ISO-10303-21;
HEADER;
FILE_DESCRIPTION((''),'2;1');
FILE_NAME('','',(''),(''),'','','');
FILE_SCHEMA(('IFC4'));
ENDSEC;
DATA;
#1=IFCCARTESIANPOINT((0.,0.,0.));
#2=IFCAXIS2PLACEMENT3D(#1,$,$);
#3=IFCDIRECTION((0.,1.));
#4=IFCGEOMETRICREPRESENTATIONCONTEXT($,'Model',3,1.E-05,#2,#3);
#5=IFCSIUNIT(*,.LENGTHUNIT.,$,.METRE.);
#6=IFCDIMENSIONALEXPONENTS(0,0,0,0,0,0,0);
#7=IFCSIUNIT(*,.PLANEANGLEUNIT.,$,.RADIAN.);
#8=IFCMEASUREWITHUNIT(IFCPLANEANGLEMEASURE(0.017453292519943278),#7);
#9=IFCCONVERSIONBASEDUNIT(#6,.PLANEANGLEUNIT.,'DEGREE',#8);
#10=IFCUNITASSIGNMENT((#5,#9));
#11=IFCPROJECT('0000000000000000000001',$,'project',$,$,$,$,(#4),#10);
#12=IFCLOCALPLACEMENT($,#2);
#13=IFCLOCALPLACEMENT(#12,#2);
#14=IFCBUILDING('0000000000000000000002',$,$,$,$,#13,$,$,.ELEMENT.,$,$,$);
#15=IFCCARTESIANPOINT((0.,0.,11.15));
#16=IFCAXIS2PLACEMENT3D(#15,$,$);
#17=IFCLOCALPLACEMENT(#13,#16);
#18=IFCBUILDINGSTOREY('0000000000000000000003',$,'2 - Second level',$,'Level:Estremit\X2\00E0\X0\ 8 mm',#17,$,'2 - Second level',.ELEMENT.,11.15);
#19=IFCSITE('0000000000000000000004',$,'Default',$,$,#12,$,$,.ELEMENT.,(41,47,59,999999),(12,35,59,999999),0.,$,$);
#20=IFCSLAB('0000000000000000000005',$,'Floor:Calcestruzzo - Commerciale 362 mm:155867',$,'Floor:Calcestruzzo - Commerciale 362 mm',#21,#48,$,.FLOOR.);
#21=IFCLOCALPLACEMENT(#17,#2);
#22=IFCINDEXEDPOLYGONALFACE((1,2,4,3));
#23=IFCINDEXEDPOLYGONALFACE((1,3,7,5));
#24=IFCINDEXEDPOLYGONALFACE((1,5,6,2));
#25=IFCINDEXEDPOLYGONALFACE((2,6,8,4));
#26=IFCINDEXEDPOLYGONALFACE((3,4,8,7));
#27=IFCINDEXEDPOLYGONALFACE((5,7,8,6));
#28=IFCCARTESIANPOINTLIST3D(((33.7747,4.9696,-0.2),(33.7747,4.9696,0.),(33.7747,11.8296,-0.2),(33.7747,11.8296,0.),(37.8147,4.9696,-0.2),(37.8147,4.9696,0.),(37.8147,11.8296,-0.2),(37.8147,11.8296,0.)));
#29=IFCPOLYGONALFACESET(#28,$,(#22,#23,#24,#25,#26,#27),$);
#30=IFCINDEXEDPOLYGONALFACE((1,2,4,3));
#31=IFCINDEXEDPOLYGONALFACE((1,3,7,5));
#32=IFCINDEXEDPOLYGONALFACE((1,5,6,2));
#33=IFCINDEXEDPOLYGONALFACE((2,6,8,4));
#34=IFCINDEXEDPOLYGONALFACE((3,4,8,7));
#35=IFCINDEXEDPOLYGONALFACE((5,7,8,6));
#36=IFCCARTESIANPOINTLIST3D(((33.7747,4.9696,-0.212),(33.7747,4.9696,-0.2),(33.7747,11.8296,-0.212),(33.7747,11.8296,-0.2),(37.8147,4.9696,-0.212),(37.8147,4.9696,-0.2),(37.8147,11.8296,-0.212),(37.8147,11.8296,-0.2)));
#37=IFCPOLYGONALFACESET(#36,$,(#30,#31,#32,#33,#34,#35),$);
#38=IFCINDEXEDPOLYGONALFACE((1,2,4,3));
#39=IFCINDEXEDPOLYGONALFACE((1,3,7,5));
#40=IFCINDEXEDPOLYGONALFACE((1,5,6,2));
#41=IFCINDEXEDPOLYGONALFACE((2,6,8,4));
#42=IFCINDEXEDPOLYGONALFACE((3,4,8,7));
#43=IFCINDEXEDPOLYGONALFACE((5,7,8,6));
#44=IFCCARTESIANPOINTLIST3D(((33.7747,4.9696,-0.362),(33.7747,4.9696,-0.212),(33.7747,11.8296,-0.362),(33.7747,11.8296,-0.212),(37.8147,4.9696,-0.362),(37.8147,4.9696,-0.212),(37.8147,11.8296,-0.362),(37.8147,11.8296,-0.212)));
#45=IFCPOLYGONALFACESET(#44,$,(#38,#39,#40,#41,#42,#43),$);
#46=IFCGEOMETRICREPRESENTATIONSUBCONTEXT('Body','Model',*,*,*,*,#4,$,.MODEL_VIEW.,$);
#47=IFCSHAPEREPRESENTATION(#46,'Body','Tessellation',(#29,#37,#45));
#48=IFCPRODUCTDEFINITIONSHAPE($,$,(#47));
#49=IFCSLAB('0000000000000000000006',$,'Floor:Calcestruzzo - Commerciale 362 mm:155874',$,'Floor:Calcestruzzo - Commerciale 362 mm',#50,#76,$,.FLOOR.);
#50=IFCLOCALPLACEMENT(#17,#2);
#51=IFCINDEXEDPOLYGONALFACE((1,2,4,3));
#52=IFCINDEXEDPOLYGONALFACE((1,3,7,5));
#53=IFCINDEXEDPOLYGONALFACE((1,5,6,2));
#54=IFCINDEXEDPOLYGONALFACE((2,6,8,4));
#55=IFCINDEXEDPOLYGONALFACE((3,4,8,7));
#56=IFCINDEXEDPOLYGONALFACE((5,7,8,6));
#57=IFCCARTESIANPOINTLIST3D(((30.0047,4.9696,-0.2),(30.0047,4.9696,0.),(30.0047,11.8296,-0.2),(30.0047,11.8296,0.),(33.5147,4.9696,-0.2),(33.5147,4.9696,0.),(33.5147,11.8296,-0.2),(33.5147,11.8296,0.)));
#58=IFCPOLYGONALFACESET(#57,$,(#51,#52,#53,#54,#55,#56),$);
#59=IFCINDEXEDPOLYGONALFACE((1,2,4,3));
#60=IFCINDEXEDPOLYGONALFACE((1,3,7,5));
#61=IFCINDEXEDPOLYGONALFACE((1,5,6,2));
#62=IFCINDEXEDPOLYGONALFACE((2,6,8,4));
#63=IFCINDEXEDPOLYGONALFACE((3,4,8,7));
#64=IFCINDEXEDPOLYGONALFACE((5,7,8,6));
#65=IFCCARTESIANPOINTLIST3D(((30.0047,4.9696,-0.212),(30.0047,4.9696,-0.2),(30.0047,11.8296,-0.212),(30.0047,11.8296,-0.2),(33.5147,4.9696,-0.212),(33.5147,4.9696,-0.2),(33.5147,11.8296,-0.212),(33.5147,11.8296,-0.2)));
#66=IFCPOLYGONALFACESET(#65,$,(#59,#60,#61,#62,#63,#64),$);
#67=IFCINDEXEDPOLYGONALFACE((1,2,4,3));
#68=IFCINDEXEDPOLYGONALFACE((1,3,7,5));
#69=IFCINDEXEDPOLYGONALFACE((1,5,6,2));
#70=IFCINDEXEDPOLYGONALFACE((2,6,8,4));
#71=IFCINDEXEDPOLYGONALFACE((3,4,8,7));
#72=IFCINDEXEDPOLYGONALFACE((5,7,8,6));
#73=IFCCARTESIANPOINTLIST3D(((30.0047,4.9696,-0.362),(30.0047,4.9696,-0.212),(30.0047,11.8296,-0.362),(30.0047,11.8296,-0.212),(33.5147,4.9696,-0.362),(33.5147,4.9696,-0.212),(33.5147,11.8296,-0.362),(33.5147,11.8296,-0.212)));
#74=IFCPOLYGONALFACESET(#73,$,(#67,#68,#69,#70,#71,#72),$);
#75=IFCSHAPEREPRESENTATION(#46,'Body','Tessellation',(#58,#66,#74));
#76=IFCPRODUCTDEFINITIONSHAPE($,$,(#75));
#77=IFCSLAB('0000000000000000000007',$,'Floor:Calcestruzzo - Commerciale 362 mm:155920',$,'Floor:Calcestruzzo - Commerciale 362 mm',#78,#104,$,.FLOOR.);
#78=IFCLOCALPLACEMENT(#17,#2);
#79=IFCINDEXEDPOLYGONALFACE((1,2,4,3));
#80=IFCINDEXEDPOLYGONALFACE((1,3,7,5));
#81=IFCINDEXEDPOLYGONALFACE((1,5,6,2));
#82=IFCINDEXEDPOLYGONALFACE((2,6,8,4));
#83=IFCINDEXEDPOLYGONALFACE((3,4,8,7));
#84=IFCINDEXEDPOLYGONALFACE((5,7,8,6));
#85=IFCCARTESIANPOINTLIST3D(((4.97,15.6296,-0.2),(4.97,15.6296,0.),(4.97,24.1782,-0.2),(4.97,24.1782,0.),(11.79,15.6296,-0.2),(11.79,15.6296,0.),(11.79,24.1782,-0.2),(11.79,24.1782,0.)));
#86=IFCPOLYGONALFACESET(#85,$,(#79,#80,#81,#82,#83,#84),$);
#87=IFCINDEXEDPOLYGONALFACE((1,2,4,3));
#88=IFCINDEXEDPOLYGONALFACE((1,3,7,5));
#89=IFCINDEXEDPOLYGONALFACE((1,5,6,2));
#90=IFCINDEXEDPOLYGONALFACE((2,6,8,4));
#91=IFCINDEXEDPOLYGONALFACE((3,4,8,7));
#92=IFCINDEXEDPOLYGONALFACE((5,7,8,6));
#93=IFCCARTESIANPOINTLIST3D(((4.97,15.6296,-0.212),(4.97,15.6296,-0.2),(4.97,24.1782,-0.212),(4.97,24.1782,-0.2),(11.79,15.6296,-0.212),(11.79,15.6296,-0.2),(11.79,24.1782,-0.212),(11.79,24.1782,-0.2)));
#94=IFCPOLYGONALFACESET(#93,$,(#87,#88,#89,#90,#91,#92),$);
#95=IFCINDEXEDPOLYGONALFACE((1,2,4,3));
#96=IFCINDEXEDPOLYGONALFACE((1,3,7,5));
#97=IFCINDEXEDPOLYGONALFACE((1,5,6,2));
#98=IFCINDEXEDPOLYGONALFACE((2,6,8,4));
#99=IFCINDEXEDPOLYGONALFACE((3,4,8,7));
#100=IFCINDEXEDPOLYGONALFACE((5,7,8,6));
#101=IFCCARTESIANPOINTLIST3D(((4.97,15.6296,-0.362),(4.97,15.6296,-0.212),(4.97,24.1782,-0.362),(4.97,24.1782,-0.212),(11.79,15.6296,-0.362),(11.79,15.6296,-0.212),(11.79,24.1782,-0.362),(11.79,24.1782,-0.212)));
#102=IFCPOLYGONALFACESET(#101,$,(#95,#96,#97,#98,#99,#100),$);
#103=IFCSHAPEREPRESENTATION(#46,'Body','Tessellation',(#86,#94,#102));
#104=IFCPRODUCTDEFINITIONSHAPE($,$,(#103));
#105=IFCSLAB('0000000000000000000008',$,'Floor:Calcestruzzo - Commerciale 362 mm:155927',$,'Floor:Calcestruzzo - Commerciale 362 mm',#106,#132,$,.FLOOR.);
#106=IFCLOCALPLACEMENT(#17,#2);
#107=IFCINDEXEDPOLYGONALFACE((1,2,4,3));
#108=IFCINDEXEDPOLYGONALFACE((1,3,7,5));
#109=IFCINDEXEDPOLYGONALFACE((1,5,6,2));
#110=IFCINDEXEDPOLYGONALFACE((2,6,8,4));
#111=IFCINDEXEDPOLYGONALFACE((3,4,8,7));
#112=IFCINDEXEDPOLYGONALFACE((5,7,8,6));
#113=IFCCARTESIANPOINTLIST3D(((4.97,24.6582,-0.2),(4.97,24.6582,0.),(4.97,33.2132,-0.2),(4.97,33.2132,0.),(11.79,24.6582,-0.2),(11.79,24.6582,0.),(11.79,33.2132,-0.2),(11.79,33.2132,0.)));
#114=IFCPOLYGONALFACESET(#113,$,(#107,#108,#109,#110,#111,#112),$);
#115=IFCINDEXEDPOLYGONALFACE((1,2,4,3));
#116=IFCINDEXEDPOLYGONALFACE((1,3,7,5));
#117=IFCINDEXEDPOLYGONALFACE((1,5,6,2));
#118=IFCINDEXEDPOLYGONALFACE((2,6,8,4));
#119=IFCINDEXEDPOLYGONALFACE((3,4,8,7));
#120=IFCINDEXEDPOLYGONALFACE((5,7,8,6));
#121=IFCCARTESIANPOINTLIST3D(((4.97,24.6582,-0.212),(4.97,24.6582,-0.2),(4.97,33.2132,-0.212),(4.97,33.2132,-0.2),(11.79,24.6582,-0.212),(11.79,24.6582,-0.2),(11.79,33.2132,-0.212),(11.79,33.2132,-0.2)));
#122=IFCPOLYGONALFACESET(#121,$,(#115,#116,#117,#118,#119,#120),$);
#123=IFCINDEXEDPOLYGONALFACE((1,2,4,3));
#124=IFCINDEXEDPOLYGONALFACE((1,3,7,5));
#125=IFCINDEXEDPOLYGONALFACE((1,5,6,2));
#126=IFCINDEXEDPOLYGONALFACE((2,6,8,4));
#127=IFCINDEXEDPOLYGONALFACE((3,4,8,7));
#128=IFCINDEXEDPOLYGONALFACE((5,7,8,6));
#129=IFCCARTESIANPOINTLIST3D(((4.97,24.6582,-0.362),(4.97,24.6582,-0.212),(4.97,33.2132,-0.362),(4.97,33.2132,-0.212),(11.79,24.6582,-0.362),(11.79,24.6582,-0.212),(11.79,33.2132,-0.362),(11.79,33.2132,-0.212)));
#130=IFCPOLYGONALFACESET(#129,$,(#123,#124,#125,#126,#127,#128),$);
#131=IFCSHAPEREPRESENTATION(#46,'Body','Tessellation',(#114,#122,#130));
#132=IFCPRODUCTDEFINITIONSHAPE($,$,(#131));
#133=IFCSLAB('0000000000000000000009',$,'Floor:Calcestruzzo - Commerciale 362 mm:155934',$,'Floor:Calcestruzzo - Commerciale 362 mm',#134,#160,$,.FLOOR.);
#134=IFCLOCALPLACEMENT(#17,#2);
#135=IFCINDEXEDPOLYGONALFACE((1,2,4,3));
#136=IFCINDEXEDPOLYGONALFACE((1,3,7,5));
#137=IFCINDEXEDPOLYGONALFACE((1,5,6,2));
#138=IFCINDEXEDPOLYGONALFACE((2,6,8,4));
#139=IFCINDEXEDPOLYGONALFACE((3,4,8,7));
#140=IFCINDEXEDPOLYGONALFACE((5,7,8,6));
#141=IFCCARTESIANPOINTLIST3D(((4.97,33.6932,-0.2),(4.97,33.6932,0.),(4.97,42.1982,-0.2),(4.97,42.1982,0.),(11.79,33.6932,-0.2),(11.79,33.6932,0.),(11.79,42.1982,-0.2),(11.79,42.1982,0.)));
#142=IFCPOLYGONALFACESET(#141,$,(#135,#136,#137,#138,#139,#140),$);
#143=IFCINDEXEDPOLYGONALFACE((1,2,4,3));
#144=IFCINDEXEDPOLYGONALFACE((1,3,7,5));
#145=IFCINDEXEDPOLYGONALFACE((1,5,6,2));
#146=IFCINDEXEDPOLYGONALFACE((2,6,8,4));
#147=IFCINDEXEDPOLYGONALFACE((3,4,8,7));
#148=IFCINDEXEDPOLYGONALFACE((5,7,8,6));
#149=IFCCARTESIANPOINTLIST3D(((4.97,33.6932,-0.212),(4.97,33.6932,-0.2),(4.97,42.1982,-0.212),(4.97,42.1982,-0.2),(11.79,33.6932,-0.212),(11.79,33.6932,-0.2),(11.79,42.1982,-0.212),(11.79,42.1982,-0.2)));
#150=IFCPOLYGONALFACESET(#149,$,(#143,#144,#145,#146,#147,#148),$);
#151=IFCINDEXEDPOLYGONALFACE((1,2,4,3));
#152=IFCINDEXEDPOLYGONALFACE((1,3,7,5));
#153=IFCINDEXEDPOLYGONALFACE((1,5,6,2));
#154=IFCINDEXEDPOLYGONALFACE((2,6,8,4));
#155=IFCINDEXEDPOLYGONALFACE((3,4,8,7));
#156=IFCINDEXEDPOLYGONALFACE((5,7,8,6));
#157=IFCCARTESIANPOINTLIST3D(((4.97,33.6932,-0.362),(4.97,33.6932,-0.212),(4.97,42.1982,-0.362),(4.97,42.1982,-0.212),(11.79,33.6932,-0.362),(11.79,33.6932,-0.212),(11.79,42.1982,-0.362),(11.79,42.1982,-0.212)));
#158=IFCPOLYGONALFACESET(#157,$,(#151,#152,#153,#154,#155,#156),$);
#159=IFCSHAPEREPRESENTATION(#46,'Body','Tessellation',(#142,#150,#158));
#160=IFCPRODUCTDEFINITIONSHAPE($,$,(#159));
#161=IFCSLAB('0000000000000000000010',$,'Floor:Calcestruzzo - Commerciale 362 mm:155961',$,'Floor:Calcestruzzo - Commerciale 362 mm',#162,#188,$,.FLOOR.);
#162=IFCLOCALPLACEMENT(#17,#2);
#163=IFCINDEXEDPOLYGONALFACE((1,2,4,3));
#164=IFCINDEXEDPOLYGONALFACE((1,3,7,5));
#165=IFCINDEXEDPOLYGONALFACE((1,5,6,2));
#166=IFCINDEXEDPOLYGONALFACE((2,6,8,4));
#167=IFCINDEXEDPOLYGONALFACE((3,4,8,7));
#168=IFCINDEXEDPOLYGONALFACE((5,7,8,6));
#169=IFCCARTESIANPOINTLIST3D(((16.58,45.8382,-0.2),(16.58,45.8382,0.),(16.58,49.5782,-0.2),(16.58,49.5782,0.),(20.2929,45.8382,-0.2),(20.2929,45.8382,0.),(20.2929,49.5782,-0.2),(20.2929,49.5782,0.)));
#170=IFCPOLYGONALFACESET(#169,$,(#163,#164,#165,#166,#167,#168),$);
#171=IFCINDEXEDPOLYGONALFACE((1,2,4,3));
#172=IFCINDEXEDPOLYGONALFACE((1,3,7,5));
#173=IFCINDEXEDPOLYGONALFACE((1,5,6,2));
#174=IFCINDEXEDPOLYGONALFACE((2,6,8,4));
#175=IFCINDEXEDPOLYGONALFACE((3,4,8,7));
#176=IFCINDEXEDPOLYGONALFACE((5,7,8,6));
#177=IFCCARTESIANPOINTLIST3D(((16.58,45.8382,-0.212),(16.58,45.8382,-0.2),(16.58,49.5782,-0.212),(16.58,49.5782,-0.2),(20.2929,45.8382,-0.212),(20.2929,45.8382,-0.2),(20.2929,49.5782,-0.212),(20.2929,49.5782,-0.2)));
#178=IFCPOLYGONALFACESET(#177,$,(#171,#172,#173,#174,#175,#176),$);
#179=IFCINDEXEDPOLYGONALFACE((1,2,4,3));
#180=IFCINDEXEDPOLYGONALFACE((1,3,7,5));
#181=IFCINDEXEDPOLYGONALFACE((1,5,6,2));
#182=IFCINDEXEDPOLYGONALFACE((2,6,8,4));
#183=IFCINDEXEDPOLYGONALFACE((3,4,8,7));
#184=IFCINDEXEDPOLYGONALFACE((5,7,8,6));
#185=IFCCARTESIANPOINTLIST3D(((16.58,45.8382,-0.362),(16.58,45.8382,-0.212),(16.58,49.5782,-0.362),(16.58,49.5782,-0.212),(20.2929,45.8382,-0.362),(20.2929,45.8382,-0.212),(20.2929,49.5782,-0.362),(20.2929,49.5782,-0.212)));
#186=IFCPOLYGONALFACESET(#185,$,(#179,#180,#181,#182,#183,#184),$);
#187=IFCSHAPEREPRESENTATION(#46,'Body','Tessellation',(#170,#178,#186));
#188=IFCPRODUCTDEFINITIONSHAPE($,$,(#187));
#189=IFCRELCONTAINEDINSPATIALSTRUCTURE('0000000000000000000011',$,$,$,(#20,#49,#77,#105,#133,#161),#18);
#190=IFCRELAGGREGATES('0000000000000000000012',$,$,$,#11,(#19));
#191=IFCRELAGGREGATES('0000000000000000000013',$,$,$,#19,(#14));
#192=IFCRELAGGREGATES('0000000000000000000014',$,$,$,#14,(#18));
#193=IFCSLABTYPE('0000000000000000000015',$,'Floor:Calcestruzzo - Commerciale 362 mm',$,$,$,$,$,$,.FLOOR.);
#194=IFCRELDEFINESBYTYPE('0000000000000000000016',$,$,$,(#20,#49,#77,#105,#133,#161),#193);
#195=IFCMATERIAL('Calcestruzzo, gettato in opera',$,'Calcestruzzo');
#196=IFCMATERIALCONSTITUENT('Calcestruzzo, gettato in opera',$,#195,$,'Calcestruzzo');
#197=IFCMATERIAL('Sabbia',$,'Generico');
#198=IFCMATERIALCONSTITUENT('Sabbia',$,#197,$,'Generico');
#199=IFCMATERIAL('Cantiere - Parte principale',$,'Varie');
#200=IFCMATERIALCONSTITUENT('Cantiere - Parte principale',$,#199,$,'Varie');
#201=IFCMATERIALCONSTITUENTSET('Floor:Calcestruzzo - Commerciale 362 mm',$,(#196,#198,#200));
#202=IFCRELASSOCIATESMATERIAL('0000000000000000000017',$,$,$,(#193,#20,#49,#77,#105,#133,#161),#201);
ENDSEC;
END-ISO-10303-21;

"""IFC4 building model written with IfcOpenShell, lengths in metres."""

from ifc_helpers import new_model, entity, si_unit, converted_unit, direction, frame, origin, place, context, subcontext, project, spatial, indexed_curve, outline, extrude, material, constituent, constituent_set, type_object, element, save


model = new_model("IFC4")

# Units and contexts
model_context = context("Model", 3, precision=1e-05, world=origin(), true_north=direction((0.0, 1.0)))
body_context = subcontext(model_context, "Body", "Model", "MODEL_VIEW")
ifc_project = project(units=[si_unit("LENGTHUNIT", "METRE"), converted_unit("PLANEANGLEUNIT", "DEGREE", entity("IfcPlaneAngleMeasure", 0.017453292519943278), si_unit("PLANEANGLEUNIT", "RADIAN"), dimensions=[0, 0, 0, 0, 0, 0, 0])], contexts=[model_context])

# Site, building, storey
site_placement = place(None, origin())
site = spatial("IfcSite", under=ifc_project, at=site_placement, Name="Default", CompositionType="ELEMENT", RefLatitude=(41, 47, 59, 999999), RefLongitude=(12, 35, 59, 999999), RefElevation=0.0)
building_placement = place(site_placement, origin())
building = spatial("IfcBuilding", under=site, at=building_placement, CompositionType="ELEMENT")
storey_placement = place(building_placement, frame((0.0, 0.0, 11.15)))
storey = spatial("IfcBuildingStorey", under=building, at=storey_placement, Name="2 - Second level", ObjectType="Level:Estremità 8 mm", LongName="2 - Second level", CompositionType="ELEMENT", Elevation=11.15)

# Slabs
ifc_material_1 = material(Name="Calcestruzzo, gettato in opera", Category="Calcestruzzo")
ifc_constituent_1 = constituent(ifc_material_1, Name="Calcestruzzo, gettato in opera", Category="Calcestruzzo")
ifc_material_2 = material(Name="Sabbia", Category="Generico")
ifc_constituent_2 = constituent(ifc_material_2, Name="Sabbia", Category="Generico")
ifc_material_3 = material(Name="Cantiere - Parte principale", Category="Varie")
ifc_constituent_3 = constituent(ifc_material_3, Name="Cantiere - Parte principale", Category="Varie")
ifc_constituent_set = constituent_set(constituents=[ifc_constituent_1, ifc_constituent_2, ifc_constituent_3], Name="Floor:Calcestruzzo - Commerciale 362 mm")
slab_type = type_object("IfcSlabType", Name="Floor:Calcestruzzo - Commerciale 362 mm", PredefinedType="FLOOR", material=ifc_constituent_set)
slab_1_placement = place(storey_placement, origin())
element("IfcSlab", 1, at=slab_1_placement, inside=storey, type_object=slab_type, material=ifc_constituent_set, Name="Floor:Calcestruzzo - Commerciale 362 mm:155867", ObjectType="Floor:Calcestruzzo - Commerciale 362 mm", PredefinedType="FLOOR", context=body_context, shape_type="SweptSolid", body=[
    extrude(outline(indexed_curve([(-2.02, -3.43), (2.02, -3.43), (2.02, 3.43), (-2.02, 3.43), (-2.02, -3.43)], self_intersect=False)), frame((35.7947, 8.3996, -0.2)), (0.0, 0.0, 1.0), 0.2),
    extrude(outline(indexed_curve([(-2.02, -3.43), (2.02, -3.43), (2.02, 3.43), (-2.02, 3.43), (-2.02, -3.43)], self_intersect=False)), frame((35.7947, 8.3996, -0.212)), (0.0, 0.0, 1.0), 0.012),
    extrude(outline(indexed_curve([(-2.02, -3.43), (2.02, -3.43), (2.02, 3.43), (-2.02, 3.43), (-2.02, -3.43)], self_intersect=False)), frame((35.7947, 8.3996, -0.362)), (0.0, 0.0, 1.0), 0.15),
])
slab_2_placement = place(storey_placement, origin())
element("IfcSlab", 2, at=slab_2_placement, inside=storey, type_object=slab_type, material=ifc_constituent_set, Name="Floor:Calcestruzzo - Commerciale 362 mm:155874", ObjectType="Floor:Calcestruzzo - Commerciale 362 mm", PredefinedType="FLOOR", context=body_context, shape_type="SweptSolid", body=[
    extrude(outline(indexed_curve([(-1.755, -3.43), (1.755, -3.43), (1.755, 3.43), (-1.755, 3.43), (-1.755, -3.43)], self_intersect=False)), frame((31.7597, 8.3996, -0.2)), (0.0, 0.0, 1.0), 0.2),
    extrude(outline(indexed_curve([(-1.755, -3.43), (1.755, -3.43), (1.755, 3.43), (-1.755, 3.43), (-1.755, -3.43)], self_intersect=False)), frame((31.7597, 8.3996, -0.212)), (0.0, 0.0, 1.0), 0.012),
    extrude(outline(indexed_curve([(-1.755, -3.43), (1.755, -3.43), (1.755, 3.43), (-1.755, 3.43), (-1.755, -3.43)], self_intersect=False)), frame((31.7597, 8.3996, -0.362)), (0.0, 0.0, 1.0), 0.15),
])
slab_3_placement = place(storey_placement, origin())
element("IfcSlab", 3, at=slab_3_placement, inside=storey, type_object=slab_type, material=ifc_constituent_set, Name="Floor:Calcestruzzo - Commerciale 362 mm:155920", ObjectType="Floor:Calcestruzzo - Commerciale 362 mm", PredefinedType="FLOOR", context=body_context, shape_type="SweptSolid", body=[
    extrude(outline(indexed_curve([(-3.41, -4.2743), (3.41, -4.2743), (3.41, 4.2743), (-3.41, 4.2743), (-3.41, -4.2743)], self_intersect=False)), frame((8.38, 19.9039, -0.2), z_axis=(0.0, 0.0, 1.0), x_axis=(-1.0, 0.0, 0.0)), (0.0, 0.0, 1.0), 0.2),
    extrude(outline(indexed_curve([(-3.41, -4.2743), (3.41, -4.2743), (3.41, 4.2743), (-3.41, 4.2743), (-3.41, -4.2743)], self_intersect=False)), frame((8.38, 19.9039, -0.212), z_axis=(0.0, 0.0, 1.0), x_axis=(-1.0, 0.0, 0.0)), (0.0, 0.0, 1.0), 0.012),
    extrude(outline(indexed_curve([(-3.41, -4.2743), (3.41, -4.2743), (3.41, 4.2743), (-3.41, 4.2743), (-3.41, -4.2743)], self_intersect=False)), frame((8.38, 19.9039, -0.362), z_axis=(0.0, 0.0, 1.0), x_axis=(-1.0, 0.0, 0.0)), (0.0, 0.0, 1.0), 0.15),
])
slab_4_placement = place(storey_placement, origin())
element("IfcSlab", 4, at=slab_4_placement, inside=storey, type_object=slab_type, material=ifc_constituent_set, Name="Floor:Calcestruzzo - Commerciale 362 mm:155927", ObjectType="Floor:Calcestruzzo - Commerciale 362 mm", PredefinedType="FLOOR", context=body_context, shape_type="SweptSolid", body=[
    extrude(outline(indexed_curve([(-3.41, -4.2775), (3.41, -4.2775), (3.41, 4.2775), (-3.41, 4.2775), (-3.41, -4.2775)], self_intersect=False)), frame((8.38, 28.9357, -0.2)), (0.0, 0.0, 1.0), 0.2),
    extrude(outline(indexed_curve([(-3.41, -4.2775), (3.41, -4.2775), (3.41, 4.2775), (-3.41, 4.2775), (-3.41, -4.2775)], self_intersect=False)), frame((8.38, 28.9357, -0.212)), (0.0, 0.0, 1.0), 0.012),
    extrude(outline(indexed_curve([(-3.41, -4.2775), (3.41, -4.2775), (3.41, 4.2775), (-3.41, 4.2775), (-3.41, -4.2775)], self_intersect=False)), frame((8.38, 28.9357, -0.362)), (0.0, 0.0, 1.0), 0.15),
])
slab_5_placement = place(storey_placement, origin())
element("IfcSlab", 5, at=slab_5_placement, inside=storey, type_object=slab_type, material=ifc_constituent_set, Name="Floor:Calcestruzzo - Commerciale 362 mm:155934", ObjectType="Floor:Calcestruzzo - Commerciale 362 mm", PredefinedType="FLOOR", context=body_context, shape_type="SweptSolid", body=[
    extrude(outline(indexed_curve([(-3.41, -4.2525), (3.41, -4.2525), (3.41, 4.2525), (-3.41, 4.2525), (-3.41, -4.2525)], self_intersect=False)), frame((8.38, 37.9457, -0.2)), (0.0, 0.0, 1.0), 0.2),
    extrude(outline(indexed_curve([(-3.41, -4.2525), (3.41, -4.2525), (3.41, 4.2525), (-3.41, 4.2525), (-3.41, -4.2525)], self_intersect=False)), frame((8.38, 37.9457, -0.212)), (0.0, 0.0, 1.0), 0.012),
    extrude(outline(indexed_curve([(-3.41, -4.2525), (3.41, -4.2525), (3.41, 4.2525), (-3.41, 4.2525), (-3.41, -4.2525)], self_intersect=False)), frame((8.38, 37.9457, -0.362)), (0.0, 0.0, 1.0), 0.15),
])
slab_6_placement = place(storey_placement, origin())
element("IfcSlab", 6, at=slab_6_placement, inside=storey, type_object=slab_type, material=ifc_constituent_set, Name="Floor:Calcestruzzo - Commerciale 362 mm:155961", ObjectType="Floor:Calcestruzzo - Commerciale 362 mm", PredefinedType="FLOOR", context=body_context, shape_type="SweptSolid", body=[
    extrude(outline(indexed_curve([(-1.8565, -1.87), (1.8565, -1.87), (1.8565, 1.87), (-1.8565, 1.87), (-1.8565, -1.87)], self_intersect=False)), frame((18.4365, 47.7082, -0.2), z_axis=(0.0, 0.0, 1.0), x_axis=(-1.0, 0.0, 0.0)), (0.0, 0.0, 1.0), 0.2),
    extrude(outline(indexed_curve([(-1.8565, -1.87), (1.8565, -1.87), (1.8565, 1.87), (-1.8565, 1.87), (-1.8565, -1.87)], self_intersect=False)), frame((18.4365, 47.7082, -0.212), z_axis=(0.0, 0.0, 1.0), x_axis=(-1.0, 0.0, 0.0)), (0.0, 0.0, 1.0), 0.012),
    extrude(outline(indexed_curve([(-1.8565, -1.87), (1.8565, -1.87), (1.8565, 1.87), (-1.8565, 1.87), (-1.8565, -1.87)], self_intersect=False)), frame((18.4365, 47.7082, -0.362), z_axis=(0.0, 0.0, 1.0), x_axis=(-1.0, 0.0, 0.0)), (0.0, 0.0, 1.0), 0.15),
])

save(model, "model.ifc")
